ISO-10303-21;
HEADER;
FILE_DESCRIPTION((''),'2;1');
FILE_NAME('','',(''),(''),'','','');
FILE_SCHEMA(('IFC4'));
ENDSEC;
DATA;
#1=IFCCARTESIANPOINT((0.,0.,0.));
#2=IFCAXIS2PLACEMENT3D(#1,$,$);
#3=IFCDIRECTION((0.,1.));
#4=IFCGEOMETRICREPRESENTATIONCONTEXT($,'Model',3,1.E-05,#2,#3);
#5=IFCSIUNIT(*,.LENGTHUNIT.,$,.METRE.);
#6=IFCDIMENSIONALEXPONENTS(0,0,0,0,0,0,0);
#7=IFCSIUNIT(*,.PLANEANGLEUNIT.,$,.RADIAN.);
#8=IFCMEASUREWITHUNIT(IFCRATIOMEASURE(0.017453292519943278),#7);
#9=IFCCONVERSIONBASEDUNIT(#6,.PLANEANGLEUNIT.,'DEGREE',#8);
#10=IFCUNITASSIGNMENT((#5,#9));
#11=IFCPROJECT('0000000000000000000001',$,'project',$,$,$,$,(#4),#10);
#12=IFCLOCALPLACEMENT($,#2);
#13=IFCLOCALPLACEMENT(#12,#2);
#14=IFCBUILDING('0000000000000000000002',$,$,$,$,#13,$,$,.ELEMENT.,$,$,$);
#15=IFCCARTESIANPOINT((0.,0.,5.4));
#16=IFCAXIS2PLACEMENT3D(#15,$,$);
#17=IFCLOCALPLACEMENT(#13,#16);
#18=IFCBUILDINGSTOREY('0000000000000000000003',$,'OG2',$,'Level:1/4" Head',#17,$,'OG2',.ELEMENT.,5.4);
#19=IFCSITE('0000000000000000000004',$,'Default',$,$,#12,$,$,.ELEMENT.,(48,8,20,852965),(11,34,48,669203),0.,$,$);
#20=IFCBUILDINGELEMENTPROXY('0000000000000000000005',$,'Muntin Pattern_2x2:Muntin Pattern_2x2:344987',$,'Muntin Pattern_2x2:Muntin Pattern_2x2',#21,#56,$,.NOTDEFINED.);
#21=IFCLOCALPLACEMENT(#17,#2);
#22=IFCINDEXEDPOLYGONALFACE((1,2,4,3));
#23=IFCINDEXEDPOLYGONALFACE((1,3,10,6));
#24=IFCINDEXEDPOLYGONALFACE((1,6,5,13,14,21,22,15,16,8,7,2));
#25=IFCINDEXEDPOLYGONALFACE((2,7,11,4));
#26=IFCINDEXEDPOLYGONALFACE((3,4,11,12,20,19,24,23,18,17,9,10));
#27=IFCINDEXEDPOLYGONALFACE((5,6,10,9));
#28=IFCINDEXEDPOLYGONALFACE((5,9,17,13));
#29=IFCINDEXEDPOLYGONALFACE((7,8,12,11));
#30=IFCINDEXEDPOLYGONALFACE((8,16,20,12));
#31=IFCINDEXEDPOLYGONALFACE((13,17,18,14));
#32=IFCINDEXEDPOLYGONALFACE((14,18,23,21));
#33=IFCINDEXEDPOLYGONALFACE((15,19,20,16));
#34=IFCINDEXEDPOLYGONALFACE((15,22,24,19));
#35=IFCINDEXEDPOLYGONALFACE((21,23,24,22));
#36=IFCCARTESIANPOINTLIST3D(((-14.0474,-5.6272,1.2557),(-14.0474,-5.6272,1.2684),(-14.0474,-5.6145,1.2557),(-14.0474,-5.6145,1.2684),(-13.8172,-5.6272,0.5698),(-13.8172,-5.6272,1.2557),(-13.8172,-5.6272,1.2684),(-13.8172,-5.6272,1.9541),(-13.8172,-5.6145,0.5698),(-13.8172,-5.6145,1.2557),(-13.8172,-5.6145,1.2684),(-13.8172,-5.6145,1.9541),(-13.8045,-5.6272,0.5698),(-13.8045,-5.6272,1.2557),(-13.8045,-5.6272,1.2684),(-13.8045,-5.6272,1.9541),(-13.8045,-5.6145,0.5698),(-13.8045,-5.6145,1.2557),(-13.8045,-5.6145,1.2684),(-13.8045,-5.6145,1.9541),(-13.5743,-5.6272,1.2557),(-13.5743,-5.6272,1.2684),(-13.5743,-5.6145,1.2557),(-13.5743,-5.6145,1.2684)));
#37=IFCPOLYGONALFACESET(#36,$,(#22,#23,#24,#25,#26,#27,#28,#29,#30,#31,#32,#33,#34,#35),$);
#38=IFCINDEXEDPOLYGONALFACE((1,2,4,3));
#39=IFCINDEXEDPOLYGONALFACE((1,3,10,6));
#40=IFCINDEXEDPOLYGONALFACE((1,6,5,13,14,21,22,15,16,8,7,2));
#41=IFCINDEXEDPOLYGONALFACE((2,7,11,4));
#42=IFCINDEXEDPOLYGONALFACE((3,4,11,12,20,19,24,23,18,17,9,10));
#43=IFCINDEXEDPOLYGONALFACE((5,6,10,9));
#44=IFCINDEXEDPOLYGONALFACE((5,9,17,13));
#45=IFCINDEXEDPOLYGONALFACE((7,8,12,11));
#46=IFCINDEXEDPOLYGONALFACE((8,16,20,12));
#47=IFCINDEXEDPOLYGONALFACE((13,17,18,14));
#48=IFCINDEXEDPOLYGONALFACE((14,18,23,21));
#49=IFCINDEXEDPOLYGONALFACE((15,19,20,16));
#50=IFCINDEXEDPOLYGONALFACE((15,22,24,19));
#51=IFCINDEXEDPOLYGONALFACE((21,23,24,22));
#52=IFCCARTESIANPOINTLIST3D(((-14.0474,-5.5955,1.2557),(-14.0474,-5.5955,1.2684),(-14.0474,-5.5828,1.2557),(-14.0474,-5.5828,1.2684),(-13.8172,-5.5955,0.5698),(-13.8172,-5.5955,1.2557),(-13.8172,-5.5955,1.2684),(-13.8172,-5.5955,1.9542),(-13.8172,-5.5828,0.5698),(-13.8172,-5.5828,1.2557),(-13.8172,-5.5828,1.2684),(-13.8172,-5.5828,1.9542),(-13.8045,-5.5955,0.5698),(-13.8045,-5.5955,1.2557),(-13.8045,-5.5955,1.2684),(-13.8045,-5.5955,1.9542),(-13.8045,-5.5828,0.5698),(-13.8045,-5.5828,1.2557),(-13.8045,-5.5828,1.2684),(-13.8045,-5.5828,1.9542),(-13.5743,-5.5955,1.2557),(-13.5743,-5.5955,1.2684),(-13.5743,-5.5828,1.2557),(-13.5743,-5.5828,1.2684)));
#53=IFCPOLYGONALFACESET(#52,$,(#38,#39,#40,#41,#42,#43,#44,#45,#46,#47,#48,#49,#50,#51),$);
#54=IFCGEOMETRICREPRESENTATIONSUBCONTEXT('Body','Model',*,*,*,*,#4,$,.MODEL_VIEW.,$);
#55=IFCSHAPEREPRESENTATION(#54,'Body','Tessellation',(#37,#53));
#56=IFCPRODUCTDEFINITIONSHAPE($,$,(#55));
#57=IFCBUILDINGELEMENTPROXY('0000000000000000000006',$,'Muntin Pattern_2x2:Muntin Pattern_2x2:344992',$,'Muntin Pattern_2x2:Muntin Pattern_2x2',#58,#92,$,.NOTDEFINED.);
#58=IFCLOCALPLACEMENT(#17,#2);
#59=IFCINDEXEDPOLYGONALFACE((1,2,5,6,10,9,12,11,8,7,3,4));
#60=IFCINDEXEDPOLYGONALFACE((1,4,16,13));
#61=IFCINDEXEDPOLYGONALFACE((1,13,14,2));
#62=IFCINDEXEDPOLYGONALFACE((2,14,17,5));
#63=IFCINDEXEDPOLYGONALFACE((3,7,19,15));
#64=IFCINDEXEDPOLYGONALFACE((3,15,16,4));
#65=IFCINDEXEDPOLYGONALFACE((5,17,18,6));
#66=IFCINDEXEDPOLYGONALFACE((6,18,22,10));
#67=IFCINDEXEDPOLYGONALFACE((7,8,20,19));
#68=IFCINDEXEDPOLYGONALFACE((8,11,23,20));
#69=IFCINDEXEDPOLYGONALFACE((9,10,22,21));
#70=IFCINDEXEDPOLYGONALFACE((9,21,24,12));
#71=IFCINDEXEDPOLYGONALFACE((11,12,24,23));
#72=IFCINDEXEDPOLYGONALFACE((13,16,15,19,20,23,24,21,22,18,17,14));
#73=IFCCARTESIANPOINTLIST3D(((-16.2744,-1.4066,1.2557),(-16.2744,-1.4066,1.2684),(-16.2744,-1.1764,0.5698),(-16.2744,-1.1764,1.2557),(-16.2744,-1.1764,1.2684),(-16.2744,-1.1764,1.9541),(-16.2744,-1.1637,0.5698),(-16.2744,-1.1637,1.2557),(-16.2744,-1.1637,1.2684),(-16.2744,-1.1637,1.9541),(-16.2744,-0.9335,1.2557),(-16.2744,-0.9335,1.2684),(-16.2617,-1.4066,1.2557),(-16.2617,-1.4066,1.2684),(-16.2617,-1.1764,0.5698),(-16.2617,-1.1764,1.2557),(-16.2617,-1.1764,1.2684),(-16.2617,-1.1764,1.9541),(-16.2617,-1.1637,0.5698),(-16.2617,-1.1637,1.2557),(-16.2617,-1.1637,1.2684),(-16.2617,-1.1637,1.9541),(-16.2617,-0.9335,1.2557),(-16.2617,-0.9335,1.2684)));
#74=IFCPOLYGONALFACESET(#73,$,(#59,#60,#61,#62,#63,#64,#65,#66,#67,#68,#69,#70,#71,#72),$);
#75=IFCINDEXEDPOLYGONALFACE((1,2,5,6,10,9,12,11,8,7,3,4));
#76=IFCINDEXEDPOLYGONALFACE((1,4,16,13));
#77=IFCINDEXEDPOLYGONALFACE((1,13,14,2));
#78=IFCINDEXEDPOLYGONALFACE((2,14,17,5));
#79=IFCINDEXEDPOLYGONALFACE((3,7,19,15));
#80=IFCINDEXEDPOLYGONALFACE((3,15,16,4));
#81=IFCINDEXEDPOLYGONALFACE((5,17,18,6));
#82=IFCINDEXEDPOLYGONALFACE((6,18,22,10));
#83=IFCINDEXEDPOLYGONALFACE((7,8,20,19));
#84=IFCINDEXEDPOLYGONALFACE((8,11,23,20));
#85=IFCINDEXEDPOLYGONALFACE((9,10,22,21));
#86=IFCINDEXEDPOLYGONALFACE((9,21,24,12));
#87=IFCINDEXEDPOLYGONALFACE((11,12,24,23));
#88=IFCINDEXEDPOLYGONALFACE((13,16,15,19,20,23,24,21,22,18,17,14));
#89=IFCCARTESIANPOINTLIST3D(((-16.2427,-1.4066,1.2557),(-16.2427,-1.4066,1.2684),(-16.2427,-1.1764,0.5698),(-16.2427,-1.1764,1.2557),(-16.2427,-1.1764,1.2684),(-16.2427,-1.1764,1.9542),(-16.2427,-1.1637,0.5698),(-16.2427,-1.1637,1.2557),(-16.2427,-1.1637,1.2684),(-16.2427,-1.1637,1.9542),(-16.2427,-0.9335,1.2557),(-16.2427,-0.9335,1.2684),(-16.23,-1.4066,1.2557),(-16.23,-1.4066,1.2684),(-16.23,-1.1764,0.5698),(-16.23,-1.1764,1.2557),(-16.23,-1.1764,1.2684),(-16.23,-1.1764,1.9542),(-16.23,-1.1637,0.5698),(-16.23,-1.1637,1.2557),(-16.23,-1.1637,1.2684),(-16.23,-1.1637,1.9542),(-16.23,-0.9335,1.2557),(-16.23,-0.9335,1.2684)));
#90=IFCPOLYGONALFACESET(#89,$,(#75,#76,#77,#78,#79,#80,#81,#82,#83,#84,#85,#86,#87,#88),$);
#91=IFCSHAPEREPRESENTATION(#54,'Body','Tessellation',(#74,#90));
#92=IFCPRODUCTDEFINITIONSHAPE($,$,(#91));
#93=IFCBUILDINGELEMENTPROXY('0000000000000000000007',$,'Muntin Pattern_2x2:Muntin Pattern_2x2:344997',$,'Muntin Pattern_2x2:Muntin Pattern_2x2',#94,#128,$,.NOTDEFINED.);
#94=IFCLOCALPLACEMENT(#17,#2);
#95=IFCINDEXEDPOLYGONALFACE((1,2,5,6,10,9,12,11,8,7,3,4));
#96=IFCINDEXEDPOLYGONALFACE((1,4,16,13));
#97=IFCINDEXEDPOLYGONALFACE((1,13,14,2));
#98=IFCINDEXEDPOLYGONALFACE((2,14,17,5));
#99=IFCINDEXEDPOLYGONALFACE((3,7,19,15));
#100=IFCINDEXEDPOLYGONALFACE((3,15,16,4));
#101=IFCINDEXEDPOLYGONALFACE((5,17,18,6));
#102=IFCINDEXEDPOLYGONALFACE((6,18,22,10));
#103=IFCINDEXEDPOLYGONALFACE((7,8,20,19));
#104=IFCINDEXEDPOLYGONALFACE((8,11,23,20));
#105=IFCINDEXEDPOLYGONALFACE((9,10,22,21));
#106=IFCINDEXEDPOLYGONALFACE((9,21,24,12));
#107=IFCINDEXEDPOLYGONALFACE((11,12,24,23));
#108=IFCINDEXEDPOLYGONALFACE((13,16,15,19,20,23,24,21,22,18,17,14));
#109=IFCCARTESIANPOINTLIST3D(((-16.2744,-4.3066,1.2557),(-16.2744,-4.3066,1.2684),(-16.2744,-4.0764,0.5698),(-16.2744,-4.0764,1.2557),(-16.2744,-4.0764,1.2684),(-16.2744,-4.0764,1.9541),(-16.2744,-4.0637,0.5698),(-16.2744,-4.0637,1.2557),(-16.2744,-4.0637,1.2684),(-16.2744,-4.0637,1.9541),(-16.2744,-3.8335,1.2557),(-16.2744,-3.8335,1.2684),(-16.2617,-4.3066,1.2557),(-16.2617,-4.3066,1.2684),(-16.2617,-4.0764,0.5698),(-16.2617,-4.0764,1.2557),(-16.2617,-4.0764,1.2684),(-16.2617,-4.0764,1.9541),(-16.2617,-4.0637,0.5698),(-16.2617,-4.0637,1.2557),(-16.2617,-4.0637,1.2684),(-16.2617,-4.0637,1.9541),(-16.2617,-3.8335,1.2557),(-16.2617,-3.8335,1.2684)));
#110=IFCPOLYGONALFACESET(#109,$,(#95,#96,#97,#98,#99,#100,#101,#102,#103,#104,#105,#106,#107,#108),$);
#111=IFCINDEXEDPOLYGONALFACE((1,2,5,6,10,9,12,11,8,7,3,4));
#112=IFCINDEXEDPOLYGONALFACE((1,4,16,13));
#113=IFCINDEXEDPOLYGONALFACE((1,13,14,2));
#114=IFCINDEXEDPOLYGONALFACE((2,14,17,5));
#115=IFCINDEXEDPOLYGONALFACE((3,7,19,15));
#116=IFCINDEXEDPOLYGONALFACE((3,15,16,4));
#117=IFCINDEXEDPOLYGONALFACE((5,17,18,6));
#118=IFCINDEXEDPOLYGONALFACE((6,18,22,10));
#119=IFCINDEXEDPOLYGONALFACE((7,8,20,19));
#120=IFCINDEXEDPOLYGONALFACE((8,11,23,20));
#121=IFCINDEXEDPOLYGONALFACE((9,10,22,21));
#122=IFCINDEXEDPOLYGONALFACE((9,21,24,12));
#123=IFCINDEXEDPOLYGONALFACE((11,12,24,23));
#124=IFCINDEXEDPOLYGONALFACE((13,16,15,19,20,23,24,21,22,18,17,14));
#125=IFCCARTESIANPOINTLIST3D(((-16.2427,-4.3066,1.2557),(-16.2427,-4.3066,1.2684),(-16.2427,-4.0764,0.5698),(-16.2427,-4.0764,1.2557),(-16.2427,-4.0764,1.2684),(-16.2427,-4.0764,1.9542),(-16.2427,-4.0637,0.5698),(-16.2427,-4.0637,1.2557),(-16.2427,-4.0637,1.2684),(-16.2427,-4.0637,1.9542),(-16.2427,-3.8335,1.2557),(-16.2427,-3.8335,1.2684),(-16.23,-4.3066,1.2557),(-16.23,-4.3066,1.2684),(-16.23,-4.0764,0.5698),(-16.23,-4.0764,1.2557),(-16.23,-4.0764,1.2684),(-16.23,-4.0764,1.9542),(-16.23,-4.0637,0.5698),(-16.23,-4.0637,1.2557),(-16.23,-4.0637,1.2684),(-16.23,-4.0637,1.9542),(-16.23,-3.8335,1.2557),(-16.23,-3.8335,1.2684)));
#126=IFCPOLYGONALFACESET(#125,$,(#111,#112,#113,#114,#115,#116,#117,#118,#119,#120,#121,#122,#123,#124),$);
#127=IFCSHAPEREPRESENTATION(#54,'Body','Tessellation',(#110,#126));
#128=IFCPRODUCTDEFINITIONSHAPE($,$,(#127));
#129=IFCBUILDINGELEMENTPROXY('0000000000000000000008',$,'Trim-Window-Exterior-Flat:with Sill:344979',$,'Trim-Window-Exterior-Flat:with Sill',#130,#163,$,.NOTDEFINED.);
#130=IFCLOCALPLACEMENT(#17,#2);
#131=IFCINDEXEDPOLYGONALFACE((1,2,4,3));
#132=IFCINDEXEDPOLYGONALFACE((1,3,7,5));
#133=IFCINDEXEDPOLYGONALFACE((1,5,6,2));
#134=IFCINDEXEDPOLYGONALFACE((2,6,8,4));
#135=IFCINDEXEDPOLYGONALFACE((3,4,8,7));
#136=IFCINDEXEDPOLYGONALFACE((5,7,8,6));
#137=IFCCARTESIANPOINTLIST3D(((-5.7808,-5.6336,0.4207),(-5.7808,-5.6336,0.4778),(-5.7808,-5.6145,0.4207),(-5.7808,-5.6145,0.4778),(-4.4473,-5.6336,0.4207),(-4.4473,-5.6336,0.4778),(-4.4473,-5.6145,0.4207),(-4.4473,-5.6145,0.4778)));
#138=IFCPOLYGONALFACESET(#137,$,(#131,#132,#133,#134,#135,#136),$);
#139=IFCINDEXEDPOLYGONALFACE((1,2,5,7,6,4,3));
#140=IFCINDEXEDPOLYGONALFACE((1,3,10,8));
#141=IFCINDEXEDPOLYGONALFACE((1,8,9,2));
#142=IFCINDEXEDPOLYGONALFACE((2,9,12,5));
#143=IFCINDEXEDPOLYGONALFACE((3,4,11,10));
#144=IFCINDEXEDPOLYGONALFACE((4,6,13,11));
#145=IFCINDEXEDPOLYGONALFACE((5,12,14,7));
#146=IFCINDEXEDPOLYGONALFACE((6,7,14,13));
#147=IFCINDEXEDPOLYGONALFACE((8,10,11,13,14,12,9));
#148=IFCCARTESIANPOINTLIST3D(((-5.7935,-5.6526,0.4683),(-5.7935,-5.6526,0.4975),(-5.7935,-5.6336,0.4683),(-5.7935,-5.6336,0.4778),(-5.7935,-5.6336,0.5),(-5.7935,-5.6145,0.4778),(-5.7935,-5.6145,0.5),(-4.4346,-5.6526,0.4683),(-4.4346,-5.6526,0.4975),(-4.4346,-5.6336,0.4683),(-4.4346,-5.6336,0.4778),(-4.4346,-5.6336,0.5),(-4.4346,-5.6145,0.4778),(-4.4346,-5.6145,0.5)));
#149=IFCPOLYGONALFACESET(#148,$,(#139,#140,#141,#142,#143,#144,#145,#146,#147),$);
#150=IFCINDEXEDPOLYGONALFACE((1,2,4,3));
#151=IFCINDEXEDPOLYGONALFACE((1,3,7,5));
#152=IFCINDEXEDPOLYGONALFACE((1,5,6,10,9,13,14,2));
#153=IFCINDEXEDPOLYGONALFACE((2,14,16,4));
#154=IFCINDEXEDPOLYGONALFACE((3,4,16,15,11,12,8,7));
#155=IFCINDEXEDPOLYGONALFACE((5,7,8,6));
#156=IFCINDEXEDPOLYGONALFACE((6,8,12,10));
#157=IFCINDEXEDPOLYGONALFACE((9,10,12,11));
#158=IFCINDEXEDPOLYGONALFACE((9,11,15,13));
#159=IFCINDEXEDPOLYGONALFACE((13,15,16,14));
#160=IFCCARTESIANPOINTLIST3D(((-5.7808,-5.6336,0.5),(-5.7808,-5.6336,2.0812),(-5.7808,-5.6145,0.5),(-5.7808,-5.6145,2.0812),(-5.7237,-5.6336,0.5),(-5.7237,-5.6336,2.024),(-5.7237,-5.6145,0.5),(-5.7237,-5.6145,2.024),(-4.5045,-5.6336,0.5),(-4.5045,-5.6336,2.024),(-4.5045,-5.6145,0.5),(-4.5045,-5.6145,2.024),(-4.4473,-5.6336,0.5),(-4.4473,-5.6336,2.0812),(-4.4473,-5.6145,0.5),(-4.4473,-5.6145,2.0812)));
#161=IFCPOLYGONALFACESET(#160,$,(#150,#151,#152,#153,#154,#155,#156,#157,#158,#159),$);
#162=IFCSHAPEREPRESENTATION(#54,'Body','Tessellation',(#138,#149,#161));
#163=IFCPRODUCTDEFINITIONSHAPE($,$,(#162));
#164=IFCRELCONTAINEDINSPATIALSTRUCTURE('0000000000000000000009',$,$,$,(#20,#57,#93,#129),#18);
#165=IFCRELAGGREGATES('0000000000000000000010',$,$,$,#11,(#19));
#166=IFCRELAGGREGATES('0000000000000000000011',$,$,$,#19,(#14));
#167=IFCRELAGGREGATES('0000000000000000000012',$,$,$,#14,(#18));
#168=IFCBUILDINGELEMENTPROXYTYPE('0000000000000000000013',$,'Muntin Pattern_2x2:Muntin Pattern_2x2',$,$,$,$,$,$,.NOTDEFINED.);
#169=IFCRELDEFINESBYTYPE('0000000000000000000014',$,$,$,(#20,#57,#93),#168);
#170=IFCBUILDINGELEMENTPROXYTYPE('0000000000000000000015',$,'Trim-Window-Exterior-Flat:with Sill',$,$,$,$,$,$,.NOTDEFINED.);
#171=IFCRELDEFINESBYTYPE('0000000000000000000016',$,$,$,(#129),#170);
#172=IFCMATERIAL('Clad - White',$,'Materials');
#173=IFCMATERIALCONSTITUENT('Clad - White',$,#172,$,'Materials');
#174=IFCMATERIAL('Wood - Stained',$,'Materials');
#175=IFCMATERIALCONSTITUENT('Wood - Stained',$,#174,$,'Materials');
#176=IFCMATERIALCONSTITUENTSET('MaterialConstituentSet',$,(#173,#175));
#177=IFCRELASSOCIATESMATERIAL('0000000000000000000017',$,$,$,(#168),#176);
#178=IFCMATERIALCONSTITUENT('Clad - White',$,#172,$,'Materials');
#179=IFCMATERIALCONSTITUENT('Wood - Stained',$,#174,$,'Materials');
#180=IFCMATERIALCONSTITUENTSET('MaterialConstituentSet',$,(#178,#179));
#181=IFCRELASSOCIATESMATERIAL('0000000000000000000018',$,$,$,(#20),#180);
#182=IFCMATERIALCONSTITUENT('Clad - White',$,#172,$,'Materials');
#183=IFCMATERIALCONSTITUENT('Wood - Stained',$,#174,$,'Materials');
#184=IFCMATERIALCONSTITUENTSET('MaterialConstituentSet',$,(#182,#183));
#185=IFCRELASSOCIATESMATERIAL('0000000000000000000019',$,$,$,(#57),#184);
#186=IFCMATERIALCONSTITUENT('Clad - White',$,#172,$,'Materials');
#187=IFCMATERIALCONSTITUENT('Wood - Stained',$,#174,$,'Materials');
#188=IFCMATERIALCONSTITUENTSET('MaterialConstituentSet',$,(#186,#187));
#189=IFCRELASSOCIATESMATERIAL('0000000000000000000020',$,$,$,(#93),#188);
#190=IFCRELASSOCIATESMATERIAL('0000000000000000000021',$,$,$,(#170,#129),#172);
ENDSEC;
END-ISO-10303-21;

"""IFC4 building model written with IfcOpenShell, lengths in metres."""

from ifc_helpers import new_model, entity, si_unit, converted_unit, direction, frame, origin, place, context, subcontext, project, spatial, indexed_curve, outline, extrude, source, transform, mapped, material, constituent, constituent_set, type_object, type_shapes, element, save


model = new_model("IFC4")

# Units and contexts
model_context = context("Model", 3, precision=1e-05, world=origin(), true_north=direction((0.0, 1.0)))
body_context = subcontext(model_context, "Body", "Model", "MODEL_VIEW")
ifc_project = project(units=[si_unit("LENGTHUNIT", "METRE"), converted_unit("PLANEANGLEUNIT", "DEGREE", entity("IfcRatioMeasure", 0.017453292519943278), si_unit("PLANEANGLEUNIT", "RADIAN"), dimensions=[0, 0, 0, 0, 0, 0, 0])], contexts=[model_context])

# Site, building, storey
site_placement = place(None, origin())
site = spatial("IfcSite", under=ifc_project, at=site_placement, Name="Default", CompositionType="ELEMENT", RefLatitude=(48, 8, 20, 852965), RefLongitude=(11, 34, 48, 669203), RefElevation=0.0)
building_placement = place(site_placement, origin())
building = spatial("IfcBuilding", under=site, at=building_placement, CompositionType="ELEMENT")
storey_placement = place(building_placement, frame((0.0, 0.0, 5.4)))
storey = spatial("IfcBuildingStorey", under=building, at=storey_placement, Name="OG2", ObjectType="Level:1/4\" Head", LongName="OG2", CompositionType="ELEMENT", Elevation=5.4)

# Building element proxies
ifc_material_1 = material(Name="Clad - White", Category="Materials")
ifc_material_2 = material(Name="Wood - Stained", Category="Materials")
ifc_constituent_1 = constituent(ifc_material_1, Name="Clad - White", Category="Materials")
ifc_constituent_2 = constituent(ifc_material_2, Name="Wood - Stained", Category="Materials")
ifc_constituent_set_1 = constituent_set(constituents=[ifc_constituent_1, ifc_constituent_2], Name="MaterialConstituentSet")
building_element_proxy_type_1 = type_object("IfcBuildingElementProxyType", Name="Muntin Pattern_2x2:Muntin Pattern_2x2", PredefinedType="NOTDEFINED", material=ifc_constituent_set_1)
shared_shape_1 = source(origin(), body_context, "Body", "SweptSolid", [
    extrude(outline(indexed_curve([(0.0064, -0.0064), (0.6921, -0.0064), (0.6921, 0.0063), (0.0064, 0.0063), (0.0064, 0.2365), (-0.0063, 0.2365), (-0.0063, 0.0063), (-0.6922, 0.0063), (-0.6922, -0.0064), (-0.0063, -0.0064), (-0.0063, -0.2365), (0.0064, -0.2365), (0.0064, -0.0064)], self_intersect=False)), frame((0.0, 0.0095, 0.6921), z_axis=(0.0, 1.0, 0.0), x_axis=(0.0, 0.0, 1.0)), (0.0, 0.0, 1.0), 0.0127),
    extrude(outline(indexed_curve([(0.0064, -0.0064), (0.6922, -0.0064), (0.6922, 0.0063), (0.0064, 0.0063), (0.0064, 0.2365), (-0.0063, 0.2365), (-0.0063, 0.0063), (-0.6922, 0.0063), (-0.6922, -0.0064), (-0.0063, -0.0064), (-0.0063, -0.2365), (0.0064, -0.2365), (0.0064, -0.0064)], self_intersect=False)), frame((0.0, -0.0222, 0.6922), z_axis=(0.0, 1.0, 0.0), x_axis=(0.0, 0.0, 1.0)), (0.0, 0.0, 1.0), 0.0127),
])
type_shapes(building_element_proxy_type_1, [shared_shape_1])
ifc_constituent_3 = constituent(ifc_material_1, Name="Clad - White", Category="Materials")
ifc_constituent_4 = constituent(ifc_material_2, Name="Wood - Stained", Category="Materials")
ifc_constituent_set_2 = constituent_set(constituents=[ifc_constituent_3, ifc_constituent_4], Name="MaterialConstituentSet")
proxy_1_placement = place(storey_placement, frame((-13.8108, -5.605, 0.5699), z_axis=(0.0, 0.0, 1.0), x_axis=(-1.0, 0.0, 0.0)))
element("IfcBuildingElementProxy", 1, at=proxy_1_placement, inside=storey, type_object=building_element_proxy_type_1, material=ifc_constituent_set_2, Name="Muntin Pattern_2x2:Muntin Pattern_2x2:344987", ObjectType="Muntin Pattern_2x2:Muntin Pattern_2x2", PredefinedType="NOTDEFINED", context=body_context, shape_type="MappedRepresentation", body=[
    mapped(shared_shape_1, transform((0.0, 0.0, 0.0), scale=1.0)),
])
ifc_constituent_5 = constituent(ifc_material_1, Name="Clad - White", Category="Materials")
ifc_constituent_6 = constituent(ifc_material_2, Name="Wood - Stained", Category="Materials")
ifc_constituent_set_3 = constituent_set(constituents=[ifc_constituent_5, ifc_constituent_6], Name="MaterialConstituentSet")
proxy_2_placement = place(storey_placement, frame((-16.2522, -1.1701, 0.5699), z_axis=(0.0, 0.0, 1.0), x_axis=(0.0, 1.0, 0.0)))
element("IfcBuildingElementProxy", 2, at=proxy_2_placement, inside=storey, type_object=building_element_proxy_type_1, material=ifc_constituent_set_3, Name="Muntin Pattern_2x2:Muntin Pattern_2x2:344992", ObjectType="Muntin Pattern_2x2:Muntin Pattern_2x2", PredefinedType="NOTDEFINED", context=body_context, shape_type="MappedRepresentation", body=[
    mapped(shared_shape_1, transform((0.0, 0.0, 0.0), scale=1.0)),
])
ifc_constituent_7 = constituent(ifc_material_1, Name="Clad - White", Category="Materials")
ifc_constituent_8 = constituent(ifc_material_2, Name="Wood - Stained", Category="Materials")
ifc_constituent_set_4 = constituent_set(constituents=[ifc_constituent_7, ifc_constituent_8], Name="MaterialConstituentSet")
proxy_3_placement = place(storey_placement, frame((-16.2522, -4.0701, 0.5699), z_axis=(0.0, 0.0, 1.0), x_axis=(0.0, 1.0, 0.0)))
element("IfcBuildingElementProxy", 3, at=proxy_3_placement, inside=storey, type_object=building_element_proxy_type_1, material=ifc_constituent_set_4, Name="Muntin Pattern_2x2:Muntin Pattern_2x2:344997", ObjectType="Muntin Pattern_2x2:Muntin Pattern_2x2", PredefinedType="NOTDEFINED", context=body_context, shape_type="MappedRepresentation", body=[
    mapped(shared_shape_1, transform((0.0, 0.0, 0.0), scale=1.0)),
])
building_element_proxy_type_2 = type_object("IfcBuildingElementProxyType", Name="Trim-Window-Exterior-Flat:with Sill", PredefinedType="NOTDEFINED", material=ifc_material_1)
shared_shape_2 = source(origin(), body_context, "Body", "SweptSolid", [
    extrude(outline(indexed_curve([(-0.6667, -0.0286), (0.6667, -0.0286), (0.6667, 0.0286), (-0.6667, 0.0286), (-0.6667, -0.0286)], self_intersect=False)), frame((0.0, -1.5748, 0.0), z_axis=(0.0, 0.0, 1.0), x_axis=(-1.0, 0.0, 0.0)), (0.0, 0.0, 1.0), 0.019),
    extrude(outline(indexed_curve([(-0.019, -0.016), (0.0, -0.016), (0.0, -0.0064), (0.019, -0.0064), (0.019, 0.0158), (0.0, 0.0158), (-0.019, 0.0133), (-0.019, -0.016)], self_intersect=False)), frame((-0.6794, -1.5398, 0.019), z_axis=(1.0, 0.0, 0.0), x_axis=(0.0, 0.0, -1.0)), (0.0, 0.0, 1.0), 1.3589),
    extrude(outline(indexed_curve([(-0.8049, -0.6667), (0.7763, -0.6667), (0.7763, -0.6096), (-0.7477, -0.6096), (-0.7477, 0.6096), (0.7763, 0.6096), (0.7763, 0.6667), (-0.8049, 0.6667), (-0.8049, -0.6667)], self_intersect=False)), frame((0.0, -0.7477, 0.0), z_axis=(0.0, 0.0, 1.0), x_axis=(0.0, -1.0, 0.0)), (0.0, 0.0, 1.0), 0.019),
])
type_shapes(building_element_proxy_type_2, [shared_shape_2])
for number, where, z_axis, x_axis, name in (
    (4, (-5.1141, -5.6145, 2.024), (0.0, -1.0, 0.0), (1.0, 0.0, 0.0), "Trim-Window-Exterior-Flat:with Sill:344979"),
):
    element("IfcBuildingElementProxy", number, at=place(storey_placement, frame(where, z_axis=z_axis, x_axis=x_axis)), inside=storey, type_object=building_element_proxy_type_2, material=ifc_material_1, Name=name, ObjectType="Trim-Window-Exterior-Flat:with Sill", PredefinedType="NOTDEFINED", context=body_context, shape_type="MappedRepresentation", body=[
        mapped(shared_shape_2, transform((0.0, 0.0, 0.0), scale=1.0)),
    ])

save(model, "model.ifc")
